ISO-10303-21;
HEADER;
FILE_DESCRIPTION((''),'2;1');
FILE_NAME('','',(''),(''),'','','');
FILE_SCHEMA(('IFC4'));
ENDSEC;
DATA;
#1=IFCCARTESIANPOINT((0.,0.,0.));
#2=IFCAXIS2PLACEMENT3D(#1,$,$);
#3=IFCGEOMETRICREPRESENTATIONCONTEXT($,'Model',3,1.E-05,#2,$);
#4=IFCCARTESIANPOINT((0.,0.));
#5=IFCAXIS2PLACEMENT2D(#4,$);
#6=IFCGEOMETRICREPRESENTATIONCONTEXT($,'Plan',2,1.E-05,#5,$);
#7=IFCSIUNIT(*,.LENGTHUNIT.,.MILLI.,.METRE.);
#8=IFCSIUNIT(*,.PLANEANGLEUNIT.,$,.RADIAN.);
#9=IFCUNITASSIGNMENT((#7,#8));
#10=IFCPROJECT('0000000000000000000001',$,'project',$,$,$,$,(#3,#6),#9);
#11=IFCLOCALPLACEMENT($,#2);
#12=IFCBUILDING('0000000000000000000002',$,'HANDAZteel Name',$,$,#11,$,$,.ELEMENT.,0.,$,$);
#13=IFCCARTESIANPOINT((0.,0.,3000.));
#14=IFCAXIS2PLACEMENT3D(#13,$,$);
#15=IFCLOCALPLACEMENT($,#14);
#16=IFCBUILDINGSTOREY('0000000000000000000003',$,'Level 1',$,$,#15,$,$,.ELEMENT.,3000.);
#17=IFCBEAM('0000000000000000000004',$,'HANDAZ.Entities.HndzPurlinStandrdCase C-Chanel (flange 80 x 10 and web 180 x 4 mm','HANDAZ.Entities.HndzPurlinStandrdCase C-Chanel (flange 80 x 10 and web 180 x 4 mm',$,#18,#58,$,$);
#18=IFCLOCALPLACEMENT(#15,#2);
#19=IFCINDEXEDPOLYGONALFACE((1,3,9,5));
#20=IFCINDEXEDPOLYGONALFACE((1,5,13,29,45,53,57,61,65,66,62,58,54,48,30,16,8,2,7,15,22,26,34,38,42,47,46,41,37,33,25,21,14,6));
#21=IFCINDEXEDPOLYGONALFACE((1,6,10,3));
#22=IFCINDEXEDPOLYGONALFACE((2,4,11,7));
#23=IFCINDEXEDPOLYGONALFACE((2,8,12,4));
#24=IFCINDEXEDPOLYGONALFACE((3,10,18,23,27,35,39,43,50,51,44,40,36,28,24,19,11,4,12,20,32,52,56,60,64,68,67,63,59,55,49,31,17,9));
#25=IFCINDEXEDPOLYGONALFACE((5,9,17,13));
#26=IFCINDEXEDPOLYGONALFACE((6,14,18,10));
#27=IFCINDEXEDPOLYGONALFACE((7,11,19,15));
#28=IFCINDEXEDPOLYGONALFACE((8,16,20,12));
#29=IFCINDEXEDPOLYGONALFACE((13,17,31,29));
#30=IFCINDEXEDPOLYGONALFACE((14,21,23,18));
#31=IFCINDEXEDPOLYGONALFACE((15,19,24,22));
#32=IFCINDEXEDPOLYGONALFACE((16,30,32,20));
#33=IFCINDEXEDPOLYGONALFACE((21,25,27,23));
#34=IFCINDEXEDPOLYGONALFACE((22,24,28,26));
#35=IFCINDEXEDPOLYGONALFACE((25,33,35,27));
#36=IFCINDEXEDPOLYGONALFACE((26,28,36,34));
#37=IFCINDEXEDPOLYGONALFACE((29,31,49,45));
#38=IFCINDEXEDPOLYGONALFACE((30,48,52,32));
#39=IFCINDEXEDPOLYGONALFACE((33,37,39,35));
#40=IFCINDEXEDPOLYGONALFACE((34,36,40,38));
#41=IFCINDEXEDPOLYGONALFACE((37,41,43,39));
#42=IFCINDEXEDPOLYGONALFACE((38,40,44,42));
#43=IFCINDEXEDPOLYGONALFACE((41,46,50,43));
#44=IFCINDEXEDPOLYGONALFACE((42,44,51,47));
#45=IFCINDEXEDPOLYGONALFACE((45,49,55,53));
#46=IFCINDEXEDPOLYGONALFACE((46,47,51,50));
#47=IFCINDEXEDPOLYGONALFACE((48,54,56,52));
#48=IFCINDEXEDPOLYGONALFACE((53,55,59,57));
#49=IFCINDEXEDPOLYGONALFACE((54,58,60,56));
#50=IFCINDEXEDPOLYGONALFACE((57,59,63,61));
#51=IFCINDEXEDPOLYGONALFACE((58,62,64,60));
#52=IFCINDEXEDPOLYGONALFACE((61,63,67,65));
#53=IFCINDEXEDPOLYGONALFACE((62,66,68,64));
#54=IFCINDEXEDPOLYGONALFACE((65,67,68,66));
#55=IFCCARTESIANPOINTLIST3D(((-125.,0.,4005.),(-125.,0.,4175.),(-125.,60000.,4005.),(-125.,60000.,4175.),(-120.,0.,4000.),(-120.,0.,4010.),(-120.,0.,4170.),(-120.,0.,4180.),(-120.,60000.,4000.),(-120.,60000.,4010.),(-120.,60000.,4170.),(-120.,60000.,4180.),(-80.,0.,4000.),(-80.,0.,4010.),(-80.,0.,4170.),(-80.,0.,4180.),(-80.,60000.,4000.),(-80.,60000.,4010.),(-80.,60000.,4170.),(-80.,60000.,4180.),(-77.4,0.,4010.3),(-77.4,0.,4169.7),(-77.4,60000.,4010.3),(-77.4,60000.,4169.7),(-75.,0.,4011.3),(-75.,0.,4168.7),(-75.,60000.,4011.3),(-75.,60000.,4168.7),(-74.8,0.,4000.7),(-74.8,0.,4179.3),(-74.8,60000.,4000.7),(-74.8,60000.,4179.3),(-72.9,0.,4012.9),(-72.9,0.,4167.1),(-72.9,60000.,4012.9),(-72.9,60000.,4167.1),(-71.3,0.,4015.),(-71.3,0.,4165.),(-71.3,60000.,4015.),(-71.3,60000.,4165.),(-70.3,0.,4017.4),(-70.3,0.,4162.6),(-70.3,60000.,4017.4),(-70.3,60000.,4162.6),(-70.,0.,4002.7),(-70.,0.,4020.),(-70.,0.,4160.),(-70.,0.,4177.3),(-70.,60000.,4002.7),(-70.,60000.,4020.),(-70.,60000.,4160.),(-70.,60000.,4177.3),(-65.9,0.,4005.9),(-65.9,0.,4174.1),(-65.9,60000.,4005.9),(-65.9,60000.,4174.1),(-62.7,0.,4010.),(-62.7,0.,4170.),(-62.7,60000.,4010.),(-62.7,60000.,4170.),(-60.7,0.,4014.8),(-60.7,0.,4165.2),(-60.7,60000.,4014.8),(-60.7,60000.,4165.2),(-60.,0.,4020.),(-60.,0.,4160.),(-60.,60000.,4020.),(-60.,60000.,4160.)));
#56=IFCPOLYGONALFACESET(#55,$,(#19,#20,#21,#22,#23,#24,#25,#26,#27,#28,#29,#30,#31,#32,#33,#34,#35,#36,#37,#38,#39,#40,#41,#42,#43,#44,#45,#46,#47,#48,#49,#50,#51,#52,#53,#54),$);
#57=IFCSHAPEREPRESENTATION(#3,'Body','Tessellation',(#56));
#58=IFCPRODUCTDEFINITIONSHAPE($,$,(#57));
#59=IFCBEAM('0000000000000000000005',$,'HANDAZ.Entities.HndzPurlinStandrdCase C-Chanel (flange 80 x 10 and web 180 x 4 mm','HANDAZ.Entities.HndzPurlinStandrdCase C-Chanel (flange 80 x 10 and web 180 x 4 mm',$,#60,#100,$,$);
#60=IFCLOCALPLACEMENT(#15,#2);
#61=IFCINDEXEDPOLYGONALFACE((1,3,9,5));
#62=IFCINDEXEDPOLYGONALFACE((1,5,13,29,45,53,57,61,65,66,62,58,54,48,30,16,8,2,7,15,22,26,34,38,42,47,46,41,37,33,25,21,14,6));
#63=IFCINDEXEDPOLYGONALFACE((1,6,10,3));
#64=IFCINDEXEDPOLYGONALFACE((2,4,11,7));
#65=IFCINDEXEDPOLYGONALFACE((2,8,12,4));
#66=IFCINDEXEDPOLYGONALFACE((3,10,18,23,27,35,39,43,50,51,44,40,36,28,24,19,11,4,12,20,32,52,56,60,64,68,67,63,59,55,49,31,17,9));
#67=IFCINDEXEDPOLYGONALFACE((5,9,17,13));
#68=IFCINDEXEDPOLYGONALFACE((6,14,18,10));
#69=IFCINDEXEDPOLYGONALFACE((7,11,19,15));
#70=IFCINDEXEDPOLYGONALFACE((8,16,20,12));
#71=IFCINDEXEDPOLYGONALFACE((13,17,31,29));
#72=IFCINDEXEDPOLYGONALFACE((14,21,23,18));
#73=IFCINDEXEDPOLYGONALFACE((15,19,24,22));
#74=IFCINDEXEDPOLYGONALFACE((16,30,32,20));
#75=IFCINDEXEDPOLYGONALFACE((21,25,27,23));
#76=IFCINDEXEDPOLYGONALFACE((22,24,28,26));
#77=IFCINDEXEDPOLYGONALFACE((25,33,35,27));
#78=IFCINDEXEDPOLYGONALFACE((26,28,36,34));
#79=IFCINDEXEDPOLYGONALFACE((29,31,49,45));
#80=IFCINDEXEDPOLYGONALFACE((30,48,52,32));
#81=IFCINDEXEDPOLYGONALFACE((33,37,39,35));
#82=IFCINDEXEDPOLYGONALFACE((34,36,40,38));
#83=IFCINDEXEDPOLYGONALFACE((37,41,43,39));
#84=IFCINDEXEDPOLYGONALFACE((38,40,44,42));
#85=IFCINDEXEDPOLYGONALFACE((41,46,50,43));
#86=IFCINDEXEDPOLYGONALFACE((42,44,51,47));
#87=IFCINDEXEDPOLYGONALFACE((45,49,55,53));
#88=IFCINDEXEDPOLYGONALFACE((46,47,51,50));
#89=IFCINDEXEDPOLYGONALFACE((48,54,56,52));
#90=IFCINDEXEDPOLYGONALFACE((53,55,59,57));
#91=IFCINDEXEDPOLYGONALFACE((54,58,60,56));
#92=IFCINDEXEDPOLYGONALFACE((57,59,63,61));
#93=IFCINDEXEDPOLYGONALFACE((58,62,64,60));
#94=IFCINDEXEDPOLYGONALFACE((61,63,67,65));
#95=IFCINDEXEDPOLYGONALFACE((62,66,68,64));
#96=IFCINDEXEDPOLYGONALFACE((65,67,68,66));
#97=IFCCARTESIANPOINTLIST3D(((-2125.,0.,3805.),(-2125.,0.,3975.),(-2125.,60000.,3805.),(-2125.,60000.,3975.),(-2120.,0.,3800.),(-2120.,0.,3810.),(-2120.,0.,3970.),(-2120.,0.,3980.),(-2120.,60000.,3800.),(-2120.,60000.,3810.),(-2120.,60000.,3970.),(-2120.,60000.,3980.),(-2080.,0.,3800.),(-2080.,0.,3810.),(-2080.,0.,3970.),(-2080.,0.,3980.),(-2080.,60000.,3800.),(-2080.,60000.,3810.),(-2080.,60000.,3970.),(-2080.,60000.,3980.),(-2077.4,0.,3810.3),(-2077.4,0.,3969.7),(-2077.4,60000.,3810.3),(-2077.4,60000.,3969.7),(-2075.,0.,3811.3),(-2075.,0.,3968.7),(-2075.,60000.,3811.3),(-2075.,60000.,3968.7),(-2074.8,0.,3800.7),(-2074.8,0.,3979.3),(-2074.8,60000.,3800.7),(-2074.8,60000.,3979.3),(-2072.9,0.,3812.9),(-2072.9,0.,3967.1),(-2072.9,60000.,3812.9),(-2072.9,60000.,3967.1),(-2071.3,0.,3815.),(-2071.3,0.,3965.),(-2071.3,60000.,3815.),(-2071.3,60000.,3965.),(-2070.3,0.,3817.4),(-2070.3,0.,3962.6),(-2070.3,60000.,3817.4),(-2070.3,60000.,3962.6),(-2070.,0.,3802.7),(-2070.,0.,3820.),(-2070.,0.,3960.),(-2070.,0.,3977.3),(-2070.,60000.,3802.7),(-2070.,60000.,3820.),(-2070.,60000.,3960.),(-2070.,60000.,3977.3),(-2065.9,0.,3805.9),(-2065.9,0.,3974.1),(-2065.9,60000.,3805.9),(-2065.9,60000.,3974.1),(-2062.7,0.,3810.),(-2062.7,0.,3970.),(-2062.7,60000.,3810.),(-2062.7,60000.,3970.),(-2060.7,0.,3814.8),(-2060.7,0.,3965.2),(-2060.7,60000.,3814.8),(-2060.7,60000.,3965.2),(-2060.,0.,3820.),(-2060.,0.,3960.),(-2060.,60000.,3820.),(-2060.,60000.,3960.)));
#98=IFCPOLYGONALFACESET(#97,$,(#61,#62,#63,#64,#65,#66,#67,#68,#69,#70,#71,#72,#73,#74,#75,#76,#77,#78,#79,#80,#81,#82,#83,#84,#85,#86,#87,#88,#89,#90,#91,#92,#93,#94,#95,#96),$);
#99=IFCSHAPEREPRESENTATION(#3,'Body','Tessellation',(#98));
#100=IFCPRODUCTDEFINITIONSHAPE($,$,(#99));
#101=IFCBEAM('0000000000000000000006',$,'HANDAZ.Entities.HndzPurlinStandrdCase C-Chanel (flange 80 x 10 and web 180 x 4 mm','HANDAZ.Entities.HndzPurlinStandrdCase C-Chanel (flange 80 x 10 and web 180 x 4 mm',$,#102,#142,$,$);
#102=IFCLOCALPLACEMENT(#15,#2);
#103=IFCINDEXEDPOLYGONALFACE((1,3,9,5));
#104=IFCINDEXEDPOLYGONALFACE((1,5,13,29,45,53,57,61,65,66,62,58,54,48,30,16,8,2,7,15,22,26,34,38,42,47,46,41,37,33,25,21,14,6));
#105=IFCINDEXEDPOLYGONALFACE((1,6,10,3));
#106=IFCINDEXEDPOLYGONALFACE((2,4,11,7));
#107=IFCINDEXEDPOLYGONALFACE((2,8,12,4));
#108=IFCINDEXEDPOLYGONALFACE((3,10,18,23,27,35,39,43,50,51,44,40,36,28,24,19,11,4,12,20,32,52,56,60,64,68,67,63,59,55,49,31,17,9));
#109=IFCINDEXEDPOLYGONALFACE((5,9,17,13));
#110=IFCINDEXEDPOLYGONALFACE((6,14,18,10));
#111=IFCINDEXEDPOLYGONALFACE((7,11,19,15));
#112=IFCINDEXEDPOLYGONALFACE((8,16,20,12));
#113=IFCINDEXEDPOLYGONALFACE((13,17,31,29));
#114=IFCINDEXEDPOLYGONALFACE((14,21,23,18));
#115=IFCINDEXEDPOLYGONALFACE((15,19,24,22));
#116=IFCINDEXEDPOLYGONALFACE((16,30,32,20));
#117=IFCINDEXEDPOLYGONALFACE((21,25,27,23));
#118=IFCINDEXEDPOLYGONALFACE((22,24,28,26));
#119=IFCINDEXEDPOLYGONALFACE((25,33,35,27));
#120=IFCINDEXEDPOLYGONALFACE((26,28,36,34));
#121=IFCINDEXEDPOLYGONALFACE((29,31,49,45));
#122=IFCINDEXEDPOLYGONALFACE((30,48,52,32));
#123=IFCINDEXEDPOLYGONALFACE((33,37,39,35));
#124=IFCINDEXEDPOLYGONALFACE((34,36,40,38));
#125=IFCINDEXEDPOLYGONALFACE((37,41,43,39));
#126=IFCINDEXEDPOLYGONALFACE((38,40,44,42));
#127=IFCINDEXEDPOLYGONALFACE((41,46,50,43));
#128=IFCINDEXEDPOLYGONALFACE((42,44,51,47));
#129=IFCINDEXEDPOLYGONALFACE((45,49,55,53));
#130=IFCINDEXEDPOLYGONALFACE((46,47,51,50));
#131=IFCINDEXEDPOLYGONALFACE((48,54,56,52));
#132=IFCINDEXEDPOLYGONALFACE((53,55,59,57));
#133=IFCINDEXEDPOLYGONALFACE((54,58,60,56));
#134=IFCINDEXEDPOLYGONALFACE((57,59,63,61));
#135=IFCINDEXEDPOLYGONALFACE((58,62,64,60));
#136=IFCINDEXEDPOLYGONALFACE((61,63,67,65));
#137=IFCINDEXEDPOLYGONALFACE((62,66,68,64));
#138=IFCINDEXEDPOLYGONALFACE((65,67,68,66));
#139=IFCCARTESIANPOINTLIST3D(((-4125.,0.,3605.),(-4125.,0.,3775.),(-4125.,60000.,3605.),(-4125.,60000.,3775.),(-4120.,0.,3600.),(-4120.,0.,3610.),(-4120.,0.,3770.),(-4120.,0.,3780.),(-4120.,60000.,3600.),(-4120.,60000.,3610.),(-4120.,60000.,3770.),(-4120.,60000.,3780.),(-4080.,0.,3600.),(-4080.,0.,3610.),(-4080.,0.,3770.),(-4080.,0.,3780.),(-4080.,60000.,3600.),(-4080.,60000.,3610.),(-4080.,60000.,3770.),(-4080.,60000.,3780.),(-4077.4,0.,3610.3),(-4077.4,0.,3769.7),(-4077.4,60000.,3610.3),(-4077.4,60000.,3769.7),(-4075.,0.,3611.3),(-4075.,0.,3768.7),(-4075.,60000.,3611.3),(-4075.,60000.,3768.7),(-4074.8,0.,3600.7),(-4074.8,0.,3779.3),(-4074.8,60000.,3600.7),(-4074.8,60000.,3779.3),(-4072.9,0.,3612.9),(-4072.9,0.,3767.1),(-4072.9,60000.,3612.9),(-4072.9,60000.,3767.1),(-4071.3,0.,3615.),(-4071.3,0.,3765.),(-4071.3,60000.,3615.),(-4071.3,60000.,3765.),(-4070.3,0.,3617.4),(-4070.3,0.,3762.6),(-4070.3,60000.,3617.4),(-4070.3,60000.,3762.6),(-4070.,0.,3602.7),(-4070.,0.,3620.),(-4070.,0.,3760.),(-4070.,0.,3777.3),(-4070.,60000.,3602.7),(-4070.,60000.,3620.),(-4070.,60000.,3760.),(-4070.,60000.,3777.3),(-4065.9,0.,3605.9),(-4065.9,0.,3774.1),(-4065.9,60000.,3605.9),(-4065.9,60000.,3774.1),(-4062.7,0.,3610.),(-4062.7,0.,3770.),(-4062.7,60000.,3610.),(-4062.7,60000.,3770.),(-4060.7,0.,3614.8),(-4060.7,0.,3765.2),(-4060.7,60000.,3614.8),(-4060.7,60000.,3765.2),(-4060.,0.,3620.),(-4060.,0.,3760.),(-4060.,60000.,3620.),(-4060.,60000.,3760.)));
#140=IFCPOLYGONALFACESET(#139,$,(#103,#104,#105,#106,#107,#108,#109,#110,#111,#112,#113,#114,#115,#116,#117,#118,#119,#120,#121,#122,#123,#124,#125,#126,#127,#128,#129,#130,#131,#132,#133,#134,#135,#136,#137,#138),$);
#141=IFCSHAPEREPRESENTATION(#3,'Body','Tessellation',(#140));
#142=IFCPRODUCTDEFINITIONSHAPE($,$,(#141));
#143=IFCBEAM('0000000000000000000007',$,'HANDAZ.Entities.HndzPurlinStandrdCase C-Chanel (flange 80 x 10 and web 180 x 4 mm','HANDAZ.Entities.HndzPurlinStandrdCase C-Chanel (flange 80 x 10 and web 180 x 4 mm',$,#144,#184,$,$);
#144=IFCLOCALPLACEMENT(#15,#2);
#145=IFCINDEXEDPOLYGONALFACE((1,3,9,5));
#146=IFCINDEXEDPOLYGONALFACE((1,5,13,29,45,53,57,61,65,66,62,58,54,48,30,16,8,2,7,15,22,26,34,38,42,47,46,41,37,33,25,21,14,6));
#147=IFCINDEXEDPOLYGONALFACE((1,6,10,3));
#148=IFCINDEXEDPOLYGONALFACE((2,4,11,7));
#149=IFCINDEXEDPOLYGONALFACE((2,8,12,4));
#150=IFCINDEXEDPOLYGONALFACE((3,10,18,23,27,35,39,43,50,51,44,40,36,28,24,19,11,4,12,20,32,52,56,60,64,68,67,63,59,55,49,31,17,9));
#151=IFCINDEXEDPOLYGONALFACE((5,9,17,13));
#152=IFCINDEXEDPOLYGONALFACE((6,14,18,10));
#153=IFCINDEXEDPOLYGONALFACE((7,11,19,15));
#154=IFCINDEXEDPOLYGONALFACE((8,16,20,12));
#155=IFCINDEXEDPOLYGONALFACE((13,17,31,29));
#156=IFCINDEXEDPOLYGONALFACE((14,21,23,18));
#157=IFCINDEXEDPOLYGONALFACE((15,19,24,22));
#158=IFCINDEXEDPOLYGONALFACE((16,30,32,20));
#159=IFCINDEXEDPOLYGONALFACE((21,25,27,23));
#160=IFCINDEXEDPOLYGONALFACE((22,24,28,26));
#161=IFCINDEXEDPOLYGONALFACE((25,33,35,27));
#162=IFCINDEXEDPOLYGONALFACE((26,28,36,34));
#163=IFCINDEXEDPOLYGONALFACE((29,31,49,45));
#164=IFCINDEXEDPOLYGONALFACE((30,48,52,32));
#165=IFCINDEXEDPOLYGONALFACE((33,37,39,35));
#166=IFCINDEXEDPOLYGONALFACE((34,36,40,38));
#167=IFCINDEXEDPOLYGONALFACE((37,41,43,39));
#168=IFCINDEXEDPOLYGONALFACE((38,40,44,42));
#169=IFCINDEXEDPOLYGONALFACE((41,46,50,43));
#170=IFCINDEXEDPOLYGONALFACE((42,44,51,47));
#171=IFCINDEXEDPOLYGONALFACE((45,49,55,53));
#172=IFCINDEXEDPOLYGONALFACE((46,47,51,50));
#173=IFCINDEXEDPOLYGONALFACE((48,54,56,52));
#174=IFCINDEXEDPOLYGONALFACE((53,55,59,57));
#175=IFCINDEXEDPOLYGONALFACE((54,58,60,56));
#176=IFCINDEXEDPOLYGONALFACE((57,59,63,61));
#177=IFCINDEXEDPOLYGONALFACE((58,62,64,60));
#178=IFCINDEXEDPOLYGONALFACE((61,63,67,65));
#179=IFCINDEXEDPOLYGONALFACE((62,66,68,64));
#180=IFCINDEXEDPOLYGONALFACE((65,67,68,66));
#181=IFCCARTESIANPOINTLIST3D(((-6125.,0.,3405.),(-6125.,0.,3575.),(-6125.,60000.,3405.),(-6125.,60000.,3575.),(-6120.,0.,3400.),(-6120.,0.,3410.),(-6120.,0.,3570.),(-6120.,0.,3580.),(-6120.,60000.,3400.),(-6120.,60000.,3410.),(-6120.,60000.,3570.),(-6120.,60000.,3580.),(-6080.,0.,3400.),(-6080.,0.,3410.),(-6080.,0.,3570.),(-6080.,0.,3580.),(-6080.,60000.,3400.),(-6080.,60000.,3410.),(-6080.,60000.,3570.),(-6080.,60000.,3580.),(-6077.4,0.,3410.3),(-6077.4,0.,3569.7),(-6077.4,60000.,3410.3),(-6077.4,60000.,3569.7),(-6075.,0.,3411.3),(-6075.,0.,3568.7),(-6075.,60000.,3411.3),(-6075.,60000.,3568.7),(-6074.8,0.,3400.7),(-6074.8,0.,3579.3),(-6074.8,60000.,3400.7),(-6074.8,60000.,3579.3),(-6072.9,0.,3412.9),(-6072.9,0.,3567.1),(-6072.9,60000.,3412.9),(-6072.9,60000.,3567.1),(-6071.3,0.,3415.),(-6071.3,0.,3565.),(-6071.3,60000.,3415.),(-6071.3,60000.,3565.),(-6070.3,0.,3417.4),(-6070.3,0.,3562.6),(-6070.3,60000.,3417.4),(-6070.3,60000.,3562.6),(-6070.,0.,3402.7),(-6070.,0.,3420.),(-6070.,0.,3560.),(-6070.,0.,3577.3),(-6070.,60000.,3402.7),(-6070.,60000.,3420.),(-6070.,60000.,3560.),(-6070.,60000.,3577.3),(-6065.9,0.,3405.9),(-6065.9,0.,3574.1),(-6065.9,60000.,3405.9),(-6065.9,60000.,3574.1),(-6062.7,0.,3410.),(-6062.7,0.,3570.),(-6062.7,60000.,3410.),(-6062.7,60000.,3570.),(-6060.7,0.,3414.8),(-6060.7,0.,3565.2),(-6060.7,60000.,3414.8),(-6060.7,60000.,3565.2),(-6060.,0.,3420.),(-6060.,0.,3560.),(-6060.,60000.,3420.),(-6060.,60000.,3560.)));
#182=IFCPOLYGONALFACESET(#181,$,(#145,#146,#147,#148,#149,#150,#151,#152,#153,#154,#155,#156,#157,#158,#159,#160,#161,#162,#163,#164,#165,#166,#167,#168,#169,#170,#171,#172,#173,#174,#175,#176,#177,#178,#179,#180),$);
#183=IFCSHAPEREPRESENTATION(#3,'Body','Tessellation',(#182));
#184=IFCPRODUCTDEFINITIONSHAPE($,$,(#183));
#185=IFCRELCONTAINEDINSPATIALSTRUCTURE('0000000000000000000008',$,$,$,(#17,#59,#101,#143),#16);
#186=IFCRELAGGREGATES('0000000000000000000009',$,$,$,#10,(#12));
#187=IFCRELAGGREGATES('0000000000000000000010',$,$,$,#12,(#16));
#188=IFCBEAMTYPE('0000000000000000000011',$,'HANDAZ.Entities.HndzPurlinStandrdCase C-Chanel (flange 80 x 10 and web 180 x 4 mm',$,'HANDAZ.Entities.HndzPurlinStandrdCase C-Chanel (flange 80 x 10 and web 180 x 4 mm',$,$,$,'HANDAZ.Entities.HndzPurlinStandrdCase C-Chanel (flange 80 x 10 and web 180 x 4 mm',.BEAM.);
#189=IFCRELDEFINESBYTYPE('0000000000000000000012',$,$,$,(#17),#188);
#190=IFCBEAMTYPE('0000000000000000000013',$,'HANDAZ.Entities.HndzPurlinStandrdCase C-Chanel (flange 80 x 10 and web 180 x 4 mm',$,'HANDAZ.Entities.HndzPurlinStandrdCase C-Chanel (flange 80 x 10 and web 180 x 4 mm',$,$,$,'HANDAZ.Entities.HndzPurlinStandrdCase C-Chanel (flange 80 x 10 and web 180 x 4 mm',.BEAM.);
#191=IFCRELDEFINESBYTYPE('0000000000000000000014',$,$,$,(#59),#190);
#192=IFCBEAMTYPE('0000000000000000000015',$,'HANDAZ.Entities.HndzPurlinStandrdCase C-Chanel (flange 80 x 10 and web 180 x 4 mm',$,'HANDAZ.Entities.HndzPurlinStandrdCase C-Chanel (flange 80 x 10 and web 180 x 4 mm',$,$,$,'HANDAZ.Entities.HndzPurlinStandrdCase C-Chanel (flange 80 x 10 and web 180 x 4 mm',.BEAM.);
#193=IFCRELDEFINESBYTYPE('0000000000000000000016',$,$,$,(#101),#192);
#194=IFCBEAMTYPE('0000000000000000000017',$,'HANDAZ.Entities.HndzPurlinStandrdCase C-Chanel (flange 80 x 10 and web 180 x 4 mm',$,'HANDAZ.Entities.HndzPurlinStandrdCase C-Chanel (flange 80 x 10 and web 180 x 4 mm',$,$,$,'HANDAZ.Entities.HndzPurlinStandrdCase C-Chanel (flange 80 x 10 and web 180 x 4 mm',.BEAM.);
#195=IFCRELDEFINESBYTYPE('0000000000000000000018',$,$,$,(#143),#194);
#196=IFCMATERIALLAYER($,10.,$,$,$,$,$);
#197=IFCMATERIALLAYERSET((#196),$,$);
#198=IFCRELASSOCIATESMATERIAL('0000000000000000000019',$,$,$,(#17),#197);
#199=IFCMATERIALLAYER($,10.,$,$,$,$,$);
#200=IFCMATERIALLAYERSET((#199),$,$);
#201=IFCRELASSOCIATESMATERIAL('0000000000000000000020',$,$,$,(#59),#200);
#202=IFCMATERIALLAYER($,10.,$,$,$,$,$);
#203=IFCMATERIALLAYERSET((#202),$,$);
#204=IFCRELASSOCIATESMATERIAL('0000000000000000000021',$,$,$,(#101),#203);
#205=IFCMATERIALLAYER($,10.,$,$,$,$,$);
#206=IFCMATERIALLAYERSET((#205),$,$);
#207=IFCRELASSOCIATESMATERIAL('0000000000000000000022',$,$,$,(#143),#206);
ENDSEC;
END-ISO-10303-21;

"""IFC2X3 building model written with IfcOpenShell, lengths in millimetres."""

from ifc_helpers import new_model, si_unit, frame, frame_2d, origin, origin_2d, place, context, project, spatial, c_section, extrude, layer, layer_set, layer_usage, type_object, element, save


model = new_model("IFC2X3")

# Units and contexts
model_context = context("Model", 3, precision=1e-05, world=origin())
plan_context = context("Plan", 2, precision=1e-05, world=origin_2d())
ifc_project = project(units=[si_unit("LENGTHUNIT", "METRE", prefix="MILLI"), si_unit("PLANEANGLEUNIT", "RADIAN")], contexts=[model_context, plan_context])

# Building, storey
building_placement = place(None, origin())
building = spatial("IfcBuilding", under=ifc_project, at=building_placement, Name="HANDAZteel Name", CompositionType="ELEMENT", ElevationOfRefHeight=0.0)
storey_placement = place(None, frame((0.0, 0.0, 3000.0)))
storey = spatial("IfcBuildingStorey", under=building, at=storey_placement, Name="Level 1", CompositionType="ELEMENT", Elevation=3000.0)

# Beams
ifc_layer_1 = layer(None, 10.0)
ifc_layer_set_1 = layer_set([ifc_layer_1])
ifc_layer_usage_1 = layer_usage(ifc_layer_set_1, "AXIS2", "NEGATIVE", 150.0)
beam_type_1 = type_object("IfcBeamType", Name="HANDAZ.Entities.HndzPurlinStandrdCase C-Chanel (flange 80 x 10 and web 180 x 4 mm", ApplicableOccurrence="HANDAZ.Entities.HndzPurlinStandrdCase C-Chanel (flange 80 x 10 and web 180 x 4 mm", ElementType="HANDAZ.Entities.HndzPurlinStandrdCase C-Chanel (flange 80 x 10 and web 180 x 4 mm", PredefinedType="BEAM")
beam_1_placement = place(None, frame((-100.0, 0.0, 7090.0), z_axis=(0.0, 1.0, 0.0), x_axis=(0.0, 0.0, 1.0)))
element("IfcBeam", 1, at=beam_1_placement, inside=storey, type_object=beam_type_1, material=ifc_layer_usage_1, Name="HANDAZ.Entities.HndzPurlinStandrdCase C-Chanel (flange 80 x 10 and web 180 x 4 mm", Description="HANDAZ.Entities.HndzPurlinStandrdCase C-Chanel (flange 80 x 10 and web 180 x 4 mm", context=model_context, shape_type="SweptSolid", body=[
    extrude(c_section(Depth=180.0, Width=80.0, WallThickness=10.0, Girth=5.0, InternalFilletRadius=10.0, at=frame_2d((0.0, 0.0), x_axis=(0.0, -1.0))), origin(), (0.0, 0.0, 1.0), 60000.0),
])
ifc_layer_2 = layer(None, 10.0)
ifc_layer_set_2 = layer_set([ifc_layer_2])
ifc_layer_usage_2 = layer_usage(ifc_layer_set_2, "AXIS2", "NEGATIVE", 150.0)
beam_type_2 = type_object("IfcBeamType", Name="HANDAZ.Entities.HndzPurlinStandrdCase C-Chanel (flange 80 x 10 and web 180 x 4 mm", ApplicableOccurrence="HANDAZ.Entities.HndzPurlinStandrdCase C-Chanel (flange 80 x 10 and web 180 x 4 mm", ElementType="HANDAZ.Entities.HndzPurlinStandrdCase C-Chanel (flange 80 x 10 and web 180 x 4 mm", PredefinedType="BEAM")
beam_2_placement = place(None, frame((-2100.0, 0.0, 6890.0), z_axis=(0.0, 1.0, 0.0), x_axis=(0.0, 0.0, 1.0)))
element("IfcBeam", 2, at=beam_2_placement, inside=storey, type_object=beam_type_2, material=ifc_layer_usage_2, Name="HANDAZ.Entities.HndzPurlinStandrdCase C-Chanel (flange 80 x 10 and web 180 x 4 mm", Description="HANDAZ.Entities.HndzPurlinStandrdCase C-Chanel (flange 80 x 10 and web 180 x 4 mm", context=model_context, shape_type="SweptSolid", body=[
    extrude(c_section(Depth=180.0, Width=80.0, WallThickness=10.0, Girth=5.0, InternalFilletRadius=10.0, at=frame_2d((0.0, 0.0), x_axis=(0.0, -1.0))), origin(), (0.0, 0.0, 1.0), 60000.0),
])
ifc_layer_3 = layer(None, 10.0)
ifc_layer_set_3 = layer_set([ifc_layer_3])
ifc_layer_usage_3 = layer_usage(ifc_layer_set_3, "AXIS2", "NEGATIVE", 150.0)
beam_type_3 = type_object("IfcBeamType", Name="HANDAZ.Entities.HndzPurlinStandrdCase C-Chanel (flange 80 x 10 and web 180 x 4 mm", ApplicableOccurrence="HANDAZ.Entities.HndzPurlinStandrdCase C-Chanel (flange 80 x 10 and web 180 x 4 mm", ElementType="HANDAZ.Entities.HndzPurlinStandrdCase C-Chanel (flange 80 x 10 and web 180 x 4 mm", PredefinedType="BEAM")
beam_3_placement = place(None, frame((-4100.0, 0.0, 6690.0), z_axis=(0.0, 1.0, 0.0), x_axis=(0.0, 0.0, 1.0)))
element("IfcBeam", 3, at=beam_3_placement, inside=storey, type_object=beam_type_3, material=ifc_layer_usage_3, Name="HANDAZ.Entities.HndzPurlinStandrdCase C-Chanel (flange 80 x 10 and web 180 x 4 mm", Description="HANDAZ.Entities.HndzPurlinStandrdCase C-Chanel (flange 80 x 10 and web 180 x 4 mm", context=model_context, shape_type="SweptSolid", body=[
    extrude(c_section(Depth=180.0, Width=80.0, WallThickness=10.0, Girth=5.0, InternalFilletRadius=10.0, at=frame_2d((0.0, 0.0), x_axis=(0.0, -1.0))), origin(), (0.0, 0.0, 1.0), 60000.0),
])
ifc_layer_4 = layer(None, 10.0)
ifc_layer_set_4 = layer_set([ifc_layer_4])
ifc_layer_usage_4 = layer_usage(ifc_layer_set_4, "AXIS2", "NEGATIVE", 150.0)
beam_type_4 = type_object("IfcBeamType", Name="HANDAZ.Entities.HndzPurlinStandrdCase C-Chanel (flange 80 x 10 and web 180 x 4 mm", ApplicableOccurrence="HANDAZ.Entities.HndzPurlinStandrdCase C-Chanel (flange 80 x 10 and web 180 x 4 mm", ElementType="HANDAZ.Entities.HndzPurlinStandrdCase C-Chanel (flange 80 x 10 and web 180 x 4 mm", PredefinedType="BEAM")
beam_4_placement = place(None, frame((-6100.0, 0.0, 6490.0), z_axis=(0.0, 1.0, 0.0), x_axis=(0.0, 0.0, 1.0)))
element("IfcBeam", 4, at=beam_4_placement, inside=storey, type_object=beam_type_4, material=ifc_layer_usage_4, Name="HANDAZ.Entities.HndzPurlinStandrdCase C-Chanel (flange 80 x 10 and web 180 x 4 mm", Description="HANDAZ.Entities.HndzPurlinStandrdCase C-Chanel (flange 80 x 10 and web 180 x 4 mm", context=model_context, shape_type="SweptSolid", body=[
    extrude(c_section(Depth=180.0, Width=80.0, WallThickness=10.0, Girth=5.0, InternalFilletRadius=10.0, at=frame_2d((0.0, 0.0), x_axis=(0.0, -1.0))), origin(), (0.0, 0.0, 1.0), 60000.0),
])

save(model, "model.ifc")
